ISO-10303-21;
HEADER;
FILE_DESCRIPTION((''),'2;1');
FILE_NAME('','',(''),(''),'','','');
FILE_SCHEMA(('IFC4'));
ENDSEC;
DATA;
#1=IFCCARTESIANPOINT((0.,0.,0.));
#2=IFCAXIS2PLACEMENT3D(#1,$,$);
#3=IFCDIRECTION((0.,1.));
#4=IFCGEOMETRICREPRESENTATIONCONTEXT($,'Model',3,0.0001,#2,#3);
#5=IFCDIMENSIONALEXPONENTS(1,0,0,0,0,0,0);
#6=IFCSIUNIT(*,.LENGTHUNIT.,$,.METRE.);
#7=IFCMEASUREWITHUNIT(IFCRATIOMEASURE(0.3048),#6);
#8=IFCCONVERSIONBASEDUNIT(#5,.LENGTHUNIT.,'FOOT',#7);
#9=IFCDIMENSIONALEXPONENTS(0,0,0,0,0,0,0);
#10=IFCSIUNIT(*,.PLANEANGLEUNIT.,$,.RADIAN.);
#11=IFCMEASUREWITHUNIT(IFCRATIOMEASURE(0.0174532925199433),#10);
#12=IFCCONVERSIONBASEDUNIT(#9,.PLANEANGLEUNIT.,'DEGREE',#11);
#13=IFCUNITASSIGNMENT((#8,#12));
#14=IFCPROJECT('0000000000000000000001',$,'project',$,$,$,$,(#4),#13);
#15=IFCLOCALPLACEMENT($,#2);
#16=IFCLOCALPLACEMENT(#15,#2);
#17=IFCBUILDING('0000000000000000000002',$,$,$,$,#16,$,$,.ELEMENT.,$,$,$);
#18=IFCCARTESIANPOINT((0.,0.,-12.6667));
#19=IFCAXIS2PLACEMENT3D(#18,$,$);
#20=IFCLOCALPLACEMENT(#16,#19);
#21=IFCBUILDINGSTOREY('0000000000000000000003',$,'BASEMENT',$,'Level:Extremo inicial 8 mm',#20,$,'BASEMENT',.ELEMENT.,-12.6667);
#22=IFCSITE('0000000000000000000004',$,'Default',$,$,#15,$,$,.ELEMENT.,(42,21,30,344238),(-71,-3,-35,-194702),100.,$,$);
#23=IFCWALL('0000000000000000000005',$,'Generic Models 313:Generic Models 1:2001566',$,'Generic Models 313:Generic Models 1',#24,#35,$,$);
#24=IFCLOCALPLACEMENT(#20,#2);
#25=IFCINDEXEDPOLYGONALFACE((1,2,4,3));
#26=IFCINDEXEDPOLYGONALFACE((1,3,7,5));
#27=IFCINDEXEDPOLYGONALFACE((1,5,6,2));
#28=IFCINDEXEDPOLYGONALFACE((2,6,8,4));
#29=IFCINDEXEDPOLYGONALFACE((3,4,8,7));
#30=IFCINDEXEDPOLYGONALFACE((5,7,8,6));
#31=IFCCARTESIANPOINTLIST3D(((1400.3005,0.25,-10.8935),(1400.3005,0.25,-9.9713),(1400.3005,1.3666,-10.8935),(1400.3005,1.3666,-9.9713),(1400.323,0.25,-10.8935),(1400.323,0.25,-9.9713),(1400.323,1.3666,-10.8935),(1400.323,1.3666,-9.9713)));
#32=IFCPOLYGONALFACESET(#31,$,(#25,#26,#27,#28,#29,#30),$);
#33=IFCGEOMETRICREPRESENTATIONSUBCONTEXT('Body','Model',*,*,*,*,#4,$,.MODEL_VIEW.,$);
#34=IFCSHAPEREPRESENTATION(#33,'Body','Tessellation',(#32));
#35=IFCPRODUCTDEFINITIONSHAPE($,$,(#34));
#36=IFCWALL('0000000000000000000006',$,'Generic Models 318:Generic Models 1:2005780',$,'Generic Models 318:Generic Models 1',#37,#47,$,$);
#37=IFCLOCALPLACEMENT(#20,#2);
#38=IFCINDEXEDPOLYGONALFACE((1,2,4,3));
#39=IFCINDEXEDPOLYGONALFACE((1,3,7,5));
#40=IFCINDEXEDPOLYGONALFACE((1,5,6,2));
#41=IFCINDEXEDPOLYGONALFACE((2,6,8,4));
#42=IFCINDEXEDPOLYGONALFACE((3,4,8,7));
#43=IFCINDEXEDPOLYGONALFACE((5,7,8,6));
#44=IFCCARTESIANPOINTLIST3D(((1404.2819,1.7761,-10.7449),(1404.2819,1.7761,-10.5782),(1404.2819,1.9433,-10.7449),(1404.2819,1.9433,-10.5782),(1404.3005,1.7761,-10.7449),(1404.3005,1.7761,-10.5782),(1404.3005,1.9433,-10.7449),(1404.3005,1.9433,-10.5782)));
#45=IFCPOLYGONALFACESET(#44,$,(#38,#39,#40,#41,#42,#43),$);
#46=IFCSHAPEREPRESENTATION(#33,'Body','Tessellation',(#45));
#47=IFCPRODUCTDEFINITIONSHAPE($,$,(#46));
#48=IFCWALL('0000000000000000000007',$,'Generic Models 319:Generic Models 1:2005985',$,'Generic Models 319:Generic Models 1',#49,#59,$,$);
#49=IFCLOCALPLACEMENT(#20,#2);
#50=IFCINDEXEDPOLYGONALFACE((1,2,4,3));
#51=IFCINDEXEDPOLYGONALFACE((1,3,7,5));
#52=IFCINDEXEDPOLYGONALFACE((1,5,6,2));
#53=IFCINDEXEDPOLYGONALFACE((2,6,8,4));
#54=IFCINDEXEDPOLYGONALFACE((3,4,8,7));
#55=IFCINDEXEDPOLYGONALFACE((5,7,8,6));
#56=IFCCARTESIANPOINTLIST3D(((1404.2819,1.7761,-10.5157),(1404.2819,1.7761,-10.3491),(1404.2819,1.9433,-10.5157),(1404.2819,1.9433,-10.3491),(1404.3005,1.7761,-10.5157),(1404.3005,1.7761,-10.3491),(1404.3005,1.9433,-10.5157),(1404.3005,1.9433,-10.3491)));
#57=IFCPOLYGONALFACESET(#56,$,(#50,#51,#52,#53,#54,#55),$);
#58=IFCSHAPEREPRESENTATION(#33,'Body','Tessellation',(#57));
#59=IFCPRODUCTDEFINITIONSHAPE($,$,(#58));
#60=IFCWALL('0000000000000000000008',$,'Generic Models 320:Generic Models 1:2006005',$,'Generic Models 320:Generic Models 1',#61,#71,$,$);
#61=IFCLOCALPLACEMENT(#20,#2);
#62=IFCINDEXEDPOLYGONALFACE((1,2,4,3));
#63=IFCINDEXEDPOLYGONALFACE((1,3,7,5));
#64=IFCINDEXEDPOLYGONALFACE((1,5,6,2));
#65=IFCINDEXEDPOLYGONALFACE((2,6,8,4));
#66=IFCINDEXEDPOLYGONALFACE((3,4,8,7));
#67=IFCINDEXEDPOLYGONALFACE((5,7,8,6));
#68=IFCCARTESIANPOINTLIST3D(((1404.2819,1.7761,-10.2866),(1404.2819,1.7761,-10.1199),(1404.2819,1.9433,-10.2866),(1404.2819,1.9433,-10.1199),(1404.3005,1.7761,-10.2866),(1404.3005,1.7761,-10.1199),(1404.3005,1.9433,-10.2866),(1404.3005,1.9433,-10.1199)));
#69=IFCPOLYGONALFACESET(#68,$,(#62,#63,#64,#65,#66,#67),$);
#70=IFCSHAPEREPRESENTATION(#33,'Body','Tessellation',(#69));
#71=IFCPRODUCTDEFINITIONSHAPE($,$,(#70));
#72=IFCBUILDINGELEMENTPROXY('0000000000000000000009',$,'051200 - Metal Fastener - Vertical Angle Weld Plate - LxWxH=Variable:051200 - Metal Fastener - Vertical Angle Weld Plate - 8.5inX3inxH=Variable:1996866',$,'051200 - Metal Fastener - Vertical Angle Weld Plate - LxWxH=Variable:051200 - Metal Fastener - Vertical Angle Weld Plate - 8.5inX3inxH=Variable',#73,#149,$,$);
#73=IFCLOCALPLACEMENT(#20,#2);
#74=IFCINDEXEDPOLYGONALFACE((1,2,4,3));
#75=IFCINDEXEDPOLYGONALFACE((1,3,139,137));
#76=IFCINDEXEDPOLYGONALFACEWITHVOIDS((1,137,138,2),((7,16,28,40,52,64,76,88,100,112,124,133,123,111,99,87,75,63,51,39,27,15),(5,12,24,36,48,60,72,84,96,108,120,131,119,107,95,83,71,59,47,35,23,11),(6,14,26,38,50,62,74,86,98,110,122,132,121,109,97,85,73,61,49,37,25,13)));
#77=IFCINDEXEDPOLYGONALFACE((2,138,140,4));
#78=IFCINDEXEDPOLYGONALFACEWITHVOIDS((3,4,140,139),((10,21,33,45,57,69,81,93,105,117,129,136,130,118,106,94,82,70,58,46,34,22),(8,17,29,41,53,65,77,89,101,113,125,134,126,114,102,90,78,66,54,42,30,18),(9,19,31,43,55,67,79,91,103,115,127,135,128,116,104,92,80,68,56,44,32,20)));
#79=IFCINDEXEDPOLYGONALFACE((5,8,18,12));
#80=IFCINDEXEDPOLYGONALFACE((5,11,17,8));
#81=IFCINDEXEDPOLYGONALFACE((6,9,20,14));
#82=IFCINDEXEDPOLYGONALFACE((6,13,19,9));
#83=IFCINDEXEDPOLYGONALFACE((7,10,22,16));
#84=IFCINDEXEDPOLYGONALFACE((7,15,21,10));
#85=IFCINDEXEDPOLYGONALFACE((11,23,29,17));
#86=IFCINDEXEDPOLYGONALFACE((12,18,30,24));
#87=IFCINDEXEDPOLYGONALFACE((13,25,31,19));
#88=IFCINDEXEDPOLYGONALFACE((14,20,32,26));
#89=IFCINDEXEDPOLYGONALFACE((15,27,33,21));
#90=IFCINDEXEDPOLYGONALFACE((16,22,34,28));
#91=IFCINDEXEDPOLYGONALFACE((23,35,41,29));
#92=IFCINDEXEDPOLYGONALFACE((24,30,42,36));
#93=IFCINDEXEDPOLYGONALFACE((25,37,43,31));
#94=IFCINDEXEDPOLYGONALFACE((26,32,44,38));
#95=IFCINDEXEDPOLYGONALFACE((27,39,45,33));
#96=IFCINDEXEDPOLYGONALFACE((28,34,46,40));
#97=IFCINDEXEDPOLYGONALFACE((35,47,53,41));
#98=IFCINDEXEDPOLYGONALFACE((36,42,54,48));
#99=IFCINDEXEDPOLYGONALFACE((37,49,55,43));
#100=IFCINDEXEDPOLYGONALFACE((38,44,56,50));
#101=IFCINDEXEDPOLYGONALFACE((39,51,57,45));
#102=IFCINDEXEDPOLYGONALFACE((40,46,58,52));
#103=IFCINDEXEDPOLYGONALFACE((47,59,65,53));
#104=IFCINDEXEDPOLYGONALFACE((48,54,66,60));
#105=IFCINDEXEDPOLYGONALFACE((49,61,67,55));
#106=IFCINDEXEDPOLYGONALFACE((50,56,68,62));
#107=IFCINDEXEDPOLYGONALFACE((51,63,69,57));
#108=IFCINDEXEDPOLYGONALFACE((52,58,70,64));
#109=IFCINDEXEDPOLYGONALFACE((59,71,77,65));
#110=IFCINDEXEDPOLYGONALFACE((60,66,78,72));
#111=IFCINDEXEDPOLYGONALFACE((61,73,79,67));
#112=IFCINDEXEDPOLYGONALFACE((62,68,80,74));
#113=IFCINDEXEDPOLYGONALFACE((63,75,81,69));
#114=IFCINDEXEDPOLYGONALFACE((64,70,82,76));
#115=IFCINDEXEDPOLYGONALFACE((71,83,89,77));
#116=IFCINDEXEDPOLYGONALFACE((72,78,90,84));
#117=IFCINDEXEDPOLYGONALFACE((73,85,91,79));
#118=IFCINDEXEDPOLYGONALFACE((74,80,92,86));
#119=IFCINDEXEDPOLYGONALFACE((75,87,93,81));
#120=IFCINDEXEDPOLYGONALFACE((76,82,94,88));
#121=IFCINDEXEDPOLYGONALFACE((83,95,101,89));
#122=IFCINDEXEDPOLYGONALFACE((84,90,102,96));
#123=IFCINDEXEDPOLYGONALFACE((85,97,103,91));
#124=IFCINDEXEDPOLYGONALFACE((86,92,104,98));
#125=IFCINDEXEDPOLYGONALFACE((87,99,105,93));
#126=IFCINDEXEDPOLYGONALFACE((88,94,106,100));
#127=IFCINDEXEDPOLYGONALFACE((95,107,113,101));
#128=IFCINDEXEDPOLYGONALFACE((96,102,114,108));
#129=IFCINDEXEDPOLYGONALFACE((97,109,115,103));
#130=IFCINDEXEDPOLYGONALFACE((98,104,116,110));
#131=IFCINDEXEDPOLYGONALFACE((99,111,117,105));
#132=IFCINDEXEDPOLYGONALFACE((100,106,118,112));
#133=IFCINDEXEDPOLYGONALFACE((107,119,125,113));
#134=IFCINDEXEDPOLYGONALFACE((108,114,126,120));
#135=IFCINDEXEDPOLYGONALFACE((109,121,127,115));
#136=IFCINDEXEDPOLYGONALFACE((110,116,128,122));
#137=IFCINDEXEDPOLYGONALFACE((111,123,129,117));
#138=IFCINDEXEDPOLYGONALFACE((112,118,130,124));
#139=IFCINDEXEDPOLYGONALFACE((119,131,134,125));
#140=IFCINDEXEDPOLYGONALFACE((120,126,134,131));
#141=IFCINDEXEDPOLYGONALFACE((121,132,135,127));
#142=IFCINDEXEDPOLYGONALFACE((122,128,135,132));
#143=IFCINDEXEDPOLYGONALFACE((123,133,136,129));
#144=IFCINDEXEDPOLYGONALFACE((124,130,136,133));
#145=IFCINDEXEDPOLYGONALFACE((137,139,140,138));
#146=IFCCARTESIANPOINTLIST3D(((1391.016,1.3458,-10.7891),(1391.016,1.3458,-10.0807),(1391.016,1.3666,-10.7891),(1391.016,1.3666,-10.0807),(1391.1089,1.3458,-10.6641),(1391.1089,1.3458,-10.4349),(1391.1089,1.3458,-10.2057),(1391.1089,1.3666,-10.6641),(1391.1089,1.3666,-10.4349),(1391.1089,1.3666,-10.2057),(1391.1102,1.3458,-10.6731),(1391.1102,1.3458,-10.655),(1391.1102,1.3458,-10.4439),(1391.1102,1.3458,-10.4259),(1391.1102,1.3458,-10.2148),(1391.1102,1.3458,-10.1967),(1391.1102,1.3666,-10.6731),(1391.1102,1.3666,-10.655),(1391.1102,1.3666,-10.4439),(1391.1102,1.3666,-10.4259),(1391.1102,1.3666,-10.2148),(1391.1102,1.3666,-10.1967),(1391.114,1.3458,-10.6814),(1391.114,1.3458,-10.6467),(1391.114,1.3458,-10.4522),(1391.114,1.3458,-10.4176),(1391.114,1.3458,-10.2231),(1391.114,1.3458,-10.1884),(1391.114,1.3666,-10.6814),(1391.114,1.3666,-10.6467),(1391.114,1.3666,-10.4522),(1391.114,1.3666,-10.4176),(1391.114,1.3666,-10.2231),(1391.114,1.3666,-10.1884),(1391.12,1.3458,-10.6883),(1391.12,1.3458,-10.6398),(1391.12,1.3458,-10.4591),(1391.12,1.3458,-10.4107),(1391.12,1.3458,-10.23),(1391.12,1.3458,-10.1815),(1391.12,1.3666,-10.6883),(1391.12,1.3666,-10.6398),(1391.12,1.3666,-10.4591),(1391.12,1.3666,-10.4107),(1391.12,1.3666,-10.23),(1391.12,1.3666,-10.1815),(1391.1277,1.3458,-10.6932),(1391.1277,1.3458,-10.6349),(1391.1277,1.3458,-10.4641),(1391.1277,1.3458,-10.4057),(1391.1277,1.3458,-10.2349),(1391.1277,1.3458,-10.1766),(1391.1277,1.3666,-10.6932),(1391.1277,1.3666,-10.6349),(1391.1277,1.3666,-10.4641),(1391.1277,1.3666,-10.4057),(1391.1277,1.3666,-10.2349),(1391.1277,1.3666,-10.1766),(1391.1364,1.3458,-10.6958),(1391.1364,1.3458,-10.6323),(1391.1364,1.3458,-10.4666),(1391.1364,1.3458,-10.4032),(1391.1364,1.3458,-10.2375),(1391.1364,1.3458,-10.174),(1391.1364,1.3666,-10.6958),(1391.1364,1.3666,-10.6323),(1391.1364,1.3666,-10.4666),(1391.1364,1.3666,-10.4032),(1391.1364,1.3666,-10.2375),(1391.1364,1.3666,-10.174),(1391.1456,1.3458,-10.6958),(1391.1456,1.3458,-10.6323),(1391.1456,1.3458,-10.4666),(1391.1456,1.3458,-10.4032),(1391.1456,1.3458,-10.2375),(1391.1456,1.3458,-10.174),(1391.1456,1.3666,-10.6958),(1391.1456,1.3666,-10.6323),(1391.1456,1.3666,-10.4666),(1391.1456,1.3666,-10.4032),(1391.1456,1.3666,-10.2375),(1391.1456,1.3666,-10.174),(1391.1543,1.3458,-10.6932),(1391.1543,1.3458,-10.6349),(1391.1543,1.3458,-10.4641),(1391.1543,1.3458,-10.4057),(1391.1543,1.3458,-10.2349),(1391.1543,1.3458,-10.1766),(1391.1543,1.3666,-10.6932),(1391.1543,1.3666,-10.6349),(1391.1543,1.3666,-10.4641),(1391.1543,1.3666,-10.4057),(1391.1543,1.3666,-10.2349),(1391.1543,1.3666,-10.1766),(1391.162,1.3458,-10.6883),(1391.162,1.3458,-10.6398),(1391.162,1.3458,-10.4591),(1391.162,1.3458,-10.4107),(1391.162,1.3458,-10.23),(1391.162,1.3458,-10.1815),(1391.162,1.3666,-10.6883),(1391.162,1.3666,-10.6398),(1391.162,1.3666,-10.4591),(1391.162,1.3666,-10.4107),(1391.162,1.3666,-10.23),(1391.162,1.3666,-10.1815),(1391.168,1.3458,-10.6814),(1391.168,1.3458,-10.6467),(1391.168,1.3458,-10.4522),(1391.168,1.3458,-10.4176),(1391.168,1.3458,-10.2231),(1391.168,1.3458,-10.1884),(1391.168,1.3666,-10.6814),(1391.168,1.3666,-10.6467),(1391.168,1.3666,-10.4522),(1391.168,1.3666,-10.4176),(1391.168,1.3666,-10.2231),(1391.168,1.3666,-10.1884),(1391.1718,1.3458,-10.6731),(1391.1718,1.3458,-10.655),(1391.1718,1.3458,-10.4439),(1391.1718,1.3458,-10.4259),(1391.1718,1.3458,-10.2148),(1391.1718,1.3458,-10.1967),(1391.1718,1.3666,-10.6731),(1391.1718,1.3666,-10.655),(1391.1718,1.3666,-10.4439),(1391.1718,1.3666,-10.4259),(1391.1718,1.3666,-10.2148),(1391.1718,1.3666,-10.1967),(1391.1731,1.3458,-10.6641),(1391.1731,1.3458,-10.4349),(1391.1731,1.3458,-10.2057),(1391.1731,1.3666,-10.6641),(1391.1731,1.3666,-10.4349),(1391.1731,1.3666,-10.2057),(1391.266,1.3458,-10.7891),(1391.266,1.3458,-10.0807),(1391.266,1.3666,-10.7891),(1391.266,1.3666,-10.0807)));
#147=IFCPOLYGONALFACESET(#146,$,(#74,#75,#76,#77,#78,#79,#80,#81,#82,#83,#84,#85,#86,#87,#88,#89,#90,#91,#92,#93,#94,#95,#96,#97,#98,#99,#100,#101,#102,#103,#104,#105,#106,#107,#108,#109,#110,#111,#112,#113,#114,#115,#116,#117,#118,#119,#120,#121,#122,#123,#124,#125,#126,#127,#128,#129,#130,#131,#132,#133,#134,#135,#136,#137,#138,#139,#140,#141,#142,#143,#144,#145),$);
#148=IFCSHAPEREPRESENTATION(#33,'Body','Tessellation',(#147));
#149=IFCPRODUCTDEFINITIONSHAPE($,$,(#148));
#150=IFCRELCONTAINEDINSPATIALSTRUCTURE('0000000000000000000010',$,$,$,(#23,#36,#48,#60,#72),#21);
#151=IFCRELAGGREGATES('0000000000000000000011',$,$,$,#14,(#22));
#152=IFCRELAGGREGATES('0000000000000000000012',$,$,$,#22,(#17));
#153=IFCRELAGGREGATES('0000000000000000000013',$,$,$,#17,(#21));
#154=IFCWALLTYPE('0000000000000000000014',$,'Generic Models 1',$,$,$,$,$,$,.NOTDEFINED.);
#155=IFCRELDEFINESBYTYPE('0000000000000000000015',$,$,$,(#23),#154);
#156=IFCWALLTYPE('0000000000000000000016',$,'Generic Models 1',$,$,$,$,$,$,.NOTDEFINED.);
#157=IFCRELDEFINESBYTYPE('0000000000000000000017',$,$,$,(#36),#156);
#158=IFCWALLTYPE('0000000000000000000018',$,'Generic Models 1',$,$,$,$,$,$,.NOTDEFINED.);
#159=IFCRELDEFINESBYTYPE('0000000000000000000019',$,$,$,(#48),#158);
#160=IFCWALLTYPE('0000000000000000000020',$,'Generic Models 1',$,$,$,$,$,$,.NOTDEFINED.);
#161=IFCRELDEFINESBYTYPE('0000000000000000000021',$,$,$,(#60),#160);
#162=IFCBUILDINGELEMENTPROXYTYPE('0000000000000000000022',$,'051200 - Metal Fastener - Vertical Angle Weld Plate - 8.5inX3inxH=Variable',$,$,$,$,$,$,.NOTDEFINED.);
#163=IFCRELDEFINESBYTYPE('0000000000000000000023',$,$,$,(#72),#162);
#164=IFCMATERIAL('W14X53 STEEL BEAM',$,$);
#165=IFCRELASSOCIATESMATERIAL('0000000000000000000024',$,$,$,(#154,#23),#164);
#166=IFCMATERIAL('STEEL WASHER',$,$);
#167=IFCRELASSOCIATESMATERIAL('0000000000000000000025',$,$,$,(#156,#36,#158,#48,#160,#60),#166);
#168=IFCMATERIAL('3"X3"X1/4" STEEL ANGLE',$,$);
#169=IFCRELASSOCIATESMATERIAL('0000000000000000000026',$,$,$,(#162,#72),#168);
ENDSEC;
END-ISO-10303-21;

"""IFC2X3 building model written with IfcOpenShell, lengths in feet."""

from ifc_helpers import new_model, entity, si_unit, converted_unit, direction, frame, frame_2d, origin, origin_2d_with_axis, place, context, subcontext, project, spatial, polyline, circle_curve, parameter, trimmed, segment, composite_curve, rectangle, outline, extrude, source, transform, mapped, material, type_object, type_shapes, element, save


model = new_model("IFC2X3")

# Units and contexts
model_context = context("Model", 3, precision=0.0001, world=origin(), true_north=direction((0.0, 1.0)))
body_context = subcontext(model_context, "Body", "Model", "MODEL_VIEW")
ifc_project = project(units=[converted_unit("LENGTHUNIT", "FOOT", entity("IfcRatioMeasure", 0.3048), si_unit("LENGTHUNIT", "METRE"), dimensions=[1, 0, 0, 0, 0, 0, 0]), converted_unit("PLANEANGLEUNIT", "DEGREE", entity("IfcRatioMeasure", 0.0174532925199433), si_unit("PLANEANGLEUNIT", "RADIAN"), dimensions=[0, 0, 0, 0, 0, 0, 0])], contexts=[model_context])

# Site, building, storey
site_placement = place(None, origin())
site = spatial("IfcSite", under=ifc_project, at=site_placement, Name="Default", CompositionType="ELEMENT", RefLatitude=(42, 21, 30, 344238), RefLongitude=(-71, -3, -35, -194702), RefElevation=100.0)
building_placement = place(site_placement, origin())
building = spatial("IfcBuilding", under=site, at=building_placement, CompositionType="ELEMENT")
storey_placement = place(building_placement, frame((0.0, 0.0, -12.6667)))
storey = spatial("IfcBuildingStorey", under=building, at=storey_placement, Name="BASEMENT", ObjectType="Level:Extremo inicial 8 mm", LongName="BASEMENT", CompositionType="ELEMENT", Elevation=-12.6667)

# Walls
ifc_material_1 = material(Name="W14X53 STEEL BEAM")
wall_type_1 = type_object("IfcWallType", Name="Generic Models 1", PredefinedType="NOTDEFINED", material=ifc_material_1)
wall_1_placement = place(storey_placement, frame((1400.3005, 0.25, -10.8935), z_axis=(0.0, 0.0, 1.0), x_axis=(0.0, 1.0, 0.0)))
element("IfcWall", 1, at=wall_1_placement, inside=storey, type_object=wall_type_1, material=ifc_material_1, Name="Generic Models 313:Generic Models 1:2001566", ObjectType="Generic Models 313:Generic Models 1", context=body_context, shape_type="SweptSolid", body=[
    extrude(rectangle(XDim=1.1166, YDim=0.0225, at=origin_2d_with_axis()), frame((0.5583, -0.0112, 0.0)), (0.0, 0.0, 1.0), 0.9222),
])
ifc_material_2 = material(Name="STEEL WASHER")
wall_type_2 = type_object("IfcWallType", Name="Generic Models 1", PredefinedType="NOTDEFINED", material=ifc_material_2)
wall_2_placement = place(storey_placement, frame((1404.2819, 1.7761, -10.7449), z_axis=(0.0, 0.0, 1.0), x_axis=(0.0, 1.0, 0.0)))
element("IfcWall", 2, at=wall_2_placement, inside=storey, type_object=wall_type_2, material=ifc_material_2, Name="Generic Models 318:Generic Models 1:2005780", ObjectType="Generic Models 318:Generic Models 1", context=body_context, shape_type="SweptSolid", body=[
    extrude(rectangle(XDim=0.1672, YDim=0.0187, at=frame_2d((0.0, 0.0), x_axis=(1.0, 0.0))), frame((0.0836, -0.0093, 0.0)), (0.0, 0.0, 1.0), 0.1667),
])
wall_type_3 = type_object("IfcWallType", Name="Generic Models 1", PredefinedType="NOTDEFINED", material=ifc_material_2)
wall_3_placement = place(storey_placement, frame((1404.2819, 1.7761, -10.5157), z_axis=(0.0, 0.0, 1.0), x_axis=(0.0, 1.0, 0.0)))
element("IfcWall", 3, at=wall_3_placement, inside=storey, type_object=wall_type_3, material=ifc_material_2, Name="Generic Models 319:Generic Models 1:2005985", ObjectType="Generic Models 319:Generic Models 1", context=body_context, shape_type="SweptSolid", body=[
    extrude(rectangle(XDim=0.1672, YDim=0.0187, at=frame_2d((0.0, 0.0), x_axis=(1.0, 0.0))), frame((0.0836, -0.0093, 0.0)), (0.0, 0.0, 1.0), 0.1667),
])
wall_type_4 = type_object("IfcWallType", Name="Generic Models 1", PredefinedType="NOTDEFINED", material=ifc_material_2)
wall_4_placement = place(storey_placement, frame((1404.2819, 1.7761, -10.2866), z_axis=(0.0, 0.0, 1.0), x_axis=(0.0, 1.0, 0.0)))
element("IfcWall", 4, at=wall_4_placement, inside=storey, type_object=wall_type_4, material=ifc_material_2, Name="Generic Models 320:Generic Models 1:2006005", ObjectType="Generic Models 320:Generic Models 1", context=body_context, shape_type="SweptSolid", body=[
    extrude(rectangle(XDim=0.1672, YDim=0.0187, at=frame_2d((0.0, 0.0), x_axis=(1.0, 0.0))), frame((0.0836, -0.0093, 0.0)), (0.0, 0.0, 1.0), 0.1667),
])

# Building element proxy
ifc_material_3 = material(Name="3\"X3\"X1/4\" STEEL ANGLE")
building_element_proxy_type_1 = type_object("IfcBuildingElementProxyType", Name="051200 - Metal Fastener - Vertical Angle Weld Plate - 8.5inX3inxH=Variable", PredefinedType="NOTDEFINED", material=ifc_material_3)
shared_shape_1 = source(origin(), body_context, "Body", "SweptSolid", [
    extrude(outline(polyline([(-0.125, -0.3542), (0.125, -0.3542), (0.125, 0.3542), (-0.125, 0.3542), (-0.125, -0.3542)]), holes=[composite_curve([segment(trimmed(circle_curve(frame_2d((0.0, -0.2292), x_axis=(-1.0, 0.0)), 0.0321), [parameter(180.0)], [parameter(0.0)], True, "PARAMETER"), False, "CONTINUOUS"), segment(trimmed(circle_curve(frame_2d((0.0, -0.2292), x_axis=(-1.0, 0.0)), 0.0321), [parameter(0.0)], [parameter(180.0)], True, "PARAMETER"), False, "CONTINUOUS")], self_intersect=False), composite_curve([segment(trimmed(circle_curve(frame_2d((0.0, 0.0), x_axis=(-1.0, 0.0)), 0.0321), [parameter(180.0)], [parameter(0.0)], True, "PARAMETER"), False, "CONTINUOUS"), segment(trimmed(circle_curve(frame_2d((0.0, 0.0), x_axis=(-1.0, 0.0)), 0.0321), [parameter(0.0)], [parameter(180.0)], True, "PARAMETER"), False, "CONTINUOUS")], self_intersect=False), composite_curve([segment(trimmed(circle_curve(frame_2d((0.0, 0.2292), x_axis=(-1.0, 0.0)), 0.0321), [parameter(180.0)], [parameter(0.0)], True, "PARAMETER"), False, "CONTINUOUS"), segment(trimmed(circle_curve(frame_2d((0.0, 0.2292), x_axis=(-1.0, 0.0)), 0.0321), [parameter(0.0)], [parameter(180.0)], True, "PARAMETER"), False, "CONTINUOUS")], self_intersect=False)]), frame((0.0, 0.0, 0.0), z_axis=(0.0, 0.0, 1.0), x_axis=(-1.0, 0.0, 0.0)), (0.0, 0.0, 1.0), 0.0208),
])
type_shapes(building_element_proxy_type_1, [shared_shape_1])
for number, where, z_axis, x_axis, name in (
    (5, (1391.141, 1.3666, -10.4349), (0.0, -1.0, 0.0), (1.0, 0.0, 0.0), "051200 - Metal Fastener - Vertical Angle Weld Plate - LxWxH=Variable:051200 - Metal Fastener - Vertical Angle Weld Plate - 8.5inX3inxH=Variable:1996866"),
):
    element("IfcBuildingElementProxy", number, at=place(storey_placement, frame(where, z_axis=z_axis, x_axis=x_axis)), inside=storey, type_object=building_element_proxy_type_1, material=ifc_material_3, Name=name, ObjectType="051200 - Metal Fastener - Vertical Angle Weld Plate - LxWxH=Variable:051200 - Metal Fastener - Vertical Angle Weld Plate - 8.5inX3inxH=Variable", context=body_context, shape_type="MappedRepresentation", body=[
        mapped(shared_shape_1, transform((0.0, 0.0, 0.0), scale=1.0)),
    ])

save(model, "model.ifc")
